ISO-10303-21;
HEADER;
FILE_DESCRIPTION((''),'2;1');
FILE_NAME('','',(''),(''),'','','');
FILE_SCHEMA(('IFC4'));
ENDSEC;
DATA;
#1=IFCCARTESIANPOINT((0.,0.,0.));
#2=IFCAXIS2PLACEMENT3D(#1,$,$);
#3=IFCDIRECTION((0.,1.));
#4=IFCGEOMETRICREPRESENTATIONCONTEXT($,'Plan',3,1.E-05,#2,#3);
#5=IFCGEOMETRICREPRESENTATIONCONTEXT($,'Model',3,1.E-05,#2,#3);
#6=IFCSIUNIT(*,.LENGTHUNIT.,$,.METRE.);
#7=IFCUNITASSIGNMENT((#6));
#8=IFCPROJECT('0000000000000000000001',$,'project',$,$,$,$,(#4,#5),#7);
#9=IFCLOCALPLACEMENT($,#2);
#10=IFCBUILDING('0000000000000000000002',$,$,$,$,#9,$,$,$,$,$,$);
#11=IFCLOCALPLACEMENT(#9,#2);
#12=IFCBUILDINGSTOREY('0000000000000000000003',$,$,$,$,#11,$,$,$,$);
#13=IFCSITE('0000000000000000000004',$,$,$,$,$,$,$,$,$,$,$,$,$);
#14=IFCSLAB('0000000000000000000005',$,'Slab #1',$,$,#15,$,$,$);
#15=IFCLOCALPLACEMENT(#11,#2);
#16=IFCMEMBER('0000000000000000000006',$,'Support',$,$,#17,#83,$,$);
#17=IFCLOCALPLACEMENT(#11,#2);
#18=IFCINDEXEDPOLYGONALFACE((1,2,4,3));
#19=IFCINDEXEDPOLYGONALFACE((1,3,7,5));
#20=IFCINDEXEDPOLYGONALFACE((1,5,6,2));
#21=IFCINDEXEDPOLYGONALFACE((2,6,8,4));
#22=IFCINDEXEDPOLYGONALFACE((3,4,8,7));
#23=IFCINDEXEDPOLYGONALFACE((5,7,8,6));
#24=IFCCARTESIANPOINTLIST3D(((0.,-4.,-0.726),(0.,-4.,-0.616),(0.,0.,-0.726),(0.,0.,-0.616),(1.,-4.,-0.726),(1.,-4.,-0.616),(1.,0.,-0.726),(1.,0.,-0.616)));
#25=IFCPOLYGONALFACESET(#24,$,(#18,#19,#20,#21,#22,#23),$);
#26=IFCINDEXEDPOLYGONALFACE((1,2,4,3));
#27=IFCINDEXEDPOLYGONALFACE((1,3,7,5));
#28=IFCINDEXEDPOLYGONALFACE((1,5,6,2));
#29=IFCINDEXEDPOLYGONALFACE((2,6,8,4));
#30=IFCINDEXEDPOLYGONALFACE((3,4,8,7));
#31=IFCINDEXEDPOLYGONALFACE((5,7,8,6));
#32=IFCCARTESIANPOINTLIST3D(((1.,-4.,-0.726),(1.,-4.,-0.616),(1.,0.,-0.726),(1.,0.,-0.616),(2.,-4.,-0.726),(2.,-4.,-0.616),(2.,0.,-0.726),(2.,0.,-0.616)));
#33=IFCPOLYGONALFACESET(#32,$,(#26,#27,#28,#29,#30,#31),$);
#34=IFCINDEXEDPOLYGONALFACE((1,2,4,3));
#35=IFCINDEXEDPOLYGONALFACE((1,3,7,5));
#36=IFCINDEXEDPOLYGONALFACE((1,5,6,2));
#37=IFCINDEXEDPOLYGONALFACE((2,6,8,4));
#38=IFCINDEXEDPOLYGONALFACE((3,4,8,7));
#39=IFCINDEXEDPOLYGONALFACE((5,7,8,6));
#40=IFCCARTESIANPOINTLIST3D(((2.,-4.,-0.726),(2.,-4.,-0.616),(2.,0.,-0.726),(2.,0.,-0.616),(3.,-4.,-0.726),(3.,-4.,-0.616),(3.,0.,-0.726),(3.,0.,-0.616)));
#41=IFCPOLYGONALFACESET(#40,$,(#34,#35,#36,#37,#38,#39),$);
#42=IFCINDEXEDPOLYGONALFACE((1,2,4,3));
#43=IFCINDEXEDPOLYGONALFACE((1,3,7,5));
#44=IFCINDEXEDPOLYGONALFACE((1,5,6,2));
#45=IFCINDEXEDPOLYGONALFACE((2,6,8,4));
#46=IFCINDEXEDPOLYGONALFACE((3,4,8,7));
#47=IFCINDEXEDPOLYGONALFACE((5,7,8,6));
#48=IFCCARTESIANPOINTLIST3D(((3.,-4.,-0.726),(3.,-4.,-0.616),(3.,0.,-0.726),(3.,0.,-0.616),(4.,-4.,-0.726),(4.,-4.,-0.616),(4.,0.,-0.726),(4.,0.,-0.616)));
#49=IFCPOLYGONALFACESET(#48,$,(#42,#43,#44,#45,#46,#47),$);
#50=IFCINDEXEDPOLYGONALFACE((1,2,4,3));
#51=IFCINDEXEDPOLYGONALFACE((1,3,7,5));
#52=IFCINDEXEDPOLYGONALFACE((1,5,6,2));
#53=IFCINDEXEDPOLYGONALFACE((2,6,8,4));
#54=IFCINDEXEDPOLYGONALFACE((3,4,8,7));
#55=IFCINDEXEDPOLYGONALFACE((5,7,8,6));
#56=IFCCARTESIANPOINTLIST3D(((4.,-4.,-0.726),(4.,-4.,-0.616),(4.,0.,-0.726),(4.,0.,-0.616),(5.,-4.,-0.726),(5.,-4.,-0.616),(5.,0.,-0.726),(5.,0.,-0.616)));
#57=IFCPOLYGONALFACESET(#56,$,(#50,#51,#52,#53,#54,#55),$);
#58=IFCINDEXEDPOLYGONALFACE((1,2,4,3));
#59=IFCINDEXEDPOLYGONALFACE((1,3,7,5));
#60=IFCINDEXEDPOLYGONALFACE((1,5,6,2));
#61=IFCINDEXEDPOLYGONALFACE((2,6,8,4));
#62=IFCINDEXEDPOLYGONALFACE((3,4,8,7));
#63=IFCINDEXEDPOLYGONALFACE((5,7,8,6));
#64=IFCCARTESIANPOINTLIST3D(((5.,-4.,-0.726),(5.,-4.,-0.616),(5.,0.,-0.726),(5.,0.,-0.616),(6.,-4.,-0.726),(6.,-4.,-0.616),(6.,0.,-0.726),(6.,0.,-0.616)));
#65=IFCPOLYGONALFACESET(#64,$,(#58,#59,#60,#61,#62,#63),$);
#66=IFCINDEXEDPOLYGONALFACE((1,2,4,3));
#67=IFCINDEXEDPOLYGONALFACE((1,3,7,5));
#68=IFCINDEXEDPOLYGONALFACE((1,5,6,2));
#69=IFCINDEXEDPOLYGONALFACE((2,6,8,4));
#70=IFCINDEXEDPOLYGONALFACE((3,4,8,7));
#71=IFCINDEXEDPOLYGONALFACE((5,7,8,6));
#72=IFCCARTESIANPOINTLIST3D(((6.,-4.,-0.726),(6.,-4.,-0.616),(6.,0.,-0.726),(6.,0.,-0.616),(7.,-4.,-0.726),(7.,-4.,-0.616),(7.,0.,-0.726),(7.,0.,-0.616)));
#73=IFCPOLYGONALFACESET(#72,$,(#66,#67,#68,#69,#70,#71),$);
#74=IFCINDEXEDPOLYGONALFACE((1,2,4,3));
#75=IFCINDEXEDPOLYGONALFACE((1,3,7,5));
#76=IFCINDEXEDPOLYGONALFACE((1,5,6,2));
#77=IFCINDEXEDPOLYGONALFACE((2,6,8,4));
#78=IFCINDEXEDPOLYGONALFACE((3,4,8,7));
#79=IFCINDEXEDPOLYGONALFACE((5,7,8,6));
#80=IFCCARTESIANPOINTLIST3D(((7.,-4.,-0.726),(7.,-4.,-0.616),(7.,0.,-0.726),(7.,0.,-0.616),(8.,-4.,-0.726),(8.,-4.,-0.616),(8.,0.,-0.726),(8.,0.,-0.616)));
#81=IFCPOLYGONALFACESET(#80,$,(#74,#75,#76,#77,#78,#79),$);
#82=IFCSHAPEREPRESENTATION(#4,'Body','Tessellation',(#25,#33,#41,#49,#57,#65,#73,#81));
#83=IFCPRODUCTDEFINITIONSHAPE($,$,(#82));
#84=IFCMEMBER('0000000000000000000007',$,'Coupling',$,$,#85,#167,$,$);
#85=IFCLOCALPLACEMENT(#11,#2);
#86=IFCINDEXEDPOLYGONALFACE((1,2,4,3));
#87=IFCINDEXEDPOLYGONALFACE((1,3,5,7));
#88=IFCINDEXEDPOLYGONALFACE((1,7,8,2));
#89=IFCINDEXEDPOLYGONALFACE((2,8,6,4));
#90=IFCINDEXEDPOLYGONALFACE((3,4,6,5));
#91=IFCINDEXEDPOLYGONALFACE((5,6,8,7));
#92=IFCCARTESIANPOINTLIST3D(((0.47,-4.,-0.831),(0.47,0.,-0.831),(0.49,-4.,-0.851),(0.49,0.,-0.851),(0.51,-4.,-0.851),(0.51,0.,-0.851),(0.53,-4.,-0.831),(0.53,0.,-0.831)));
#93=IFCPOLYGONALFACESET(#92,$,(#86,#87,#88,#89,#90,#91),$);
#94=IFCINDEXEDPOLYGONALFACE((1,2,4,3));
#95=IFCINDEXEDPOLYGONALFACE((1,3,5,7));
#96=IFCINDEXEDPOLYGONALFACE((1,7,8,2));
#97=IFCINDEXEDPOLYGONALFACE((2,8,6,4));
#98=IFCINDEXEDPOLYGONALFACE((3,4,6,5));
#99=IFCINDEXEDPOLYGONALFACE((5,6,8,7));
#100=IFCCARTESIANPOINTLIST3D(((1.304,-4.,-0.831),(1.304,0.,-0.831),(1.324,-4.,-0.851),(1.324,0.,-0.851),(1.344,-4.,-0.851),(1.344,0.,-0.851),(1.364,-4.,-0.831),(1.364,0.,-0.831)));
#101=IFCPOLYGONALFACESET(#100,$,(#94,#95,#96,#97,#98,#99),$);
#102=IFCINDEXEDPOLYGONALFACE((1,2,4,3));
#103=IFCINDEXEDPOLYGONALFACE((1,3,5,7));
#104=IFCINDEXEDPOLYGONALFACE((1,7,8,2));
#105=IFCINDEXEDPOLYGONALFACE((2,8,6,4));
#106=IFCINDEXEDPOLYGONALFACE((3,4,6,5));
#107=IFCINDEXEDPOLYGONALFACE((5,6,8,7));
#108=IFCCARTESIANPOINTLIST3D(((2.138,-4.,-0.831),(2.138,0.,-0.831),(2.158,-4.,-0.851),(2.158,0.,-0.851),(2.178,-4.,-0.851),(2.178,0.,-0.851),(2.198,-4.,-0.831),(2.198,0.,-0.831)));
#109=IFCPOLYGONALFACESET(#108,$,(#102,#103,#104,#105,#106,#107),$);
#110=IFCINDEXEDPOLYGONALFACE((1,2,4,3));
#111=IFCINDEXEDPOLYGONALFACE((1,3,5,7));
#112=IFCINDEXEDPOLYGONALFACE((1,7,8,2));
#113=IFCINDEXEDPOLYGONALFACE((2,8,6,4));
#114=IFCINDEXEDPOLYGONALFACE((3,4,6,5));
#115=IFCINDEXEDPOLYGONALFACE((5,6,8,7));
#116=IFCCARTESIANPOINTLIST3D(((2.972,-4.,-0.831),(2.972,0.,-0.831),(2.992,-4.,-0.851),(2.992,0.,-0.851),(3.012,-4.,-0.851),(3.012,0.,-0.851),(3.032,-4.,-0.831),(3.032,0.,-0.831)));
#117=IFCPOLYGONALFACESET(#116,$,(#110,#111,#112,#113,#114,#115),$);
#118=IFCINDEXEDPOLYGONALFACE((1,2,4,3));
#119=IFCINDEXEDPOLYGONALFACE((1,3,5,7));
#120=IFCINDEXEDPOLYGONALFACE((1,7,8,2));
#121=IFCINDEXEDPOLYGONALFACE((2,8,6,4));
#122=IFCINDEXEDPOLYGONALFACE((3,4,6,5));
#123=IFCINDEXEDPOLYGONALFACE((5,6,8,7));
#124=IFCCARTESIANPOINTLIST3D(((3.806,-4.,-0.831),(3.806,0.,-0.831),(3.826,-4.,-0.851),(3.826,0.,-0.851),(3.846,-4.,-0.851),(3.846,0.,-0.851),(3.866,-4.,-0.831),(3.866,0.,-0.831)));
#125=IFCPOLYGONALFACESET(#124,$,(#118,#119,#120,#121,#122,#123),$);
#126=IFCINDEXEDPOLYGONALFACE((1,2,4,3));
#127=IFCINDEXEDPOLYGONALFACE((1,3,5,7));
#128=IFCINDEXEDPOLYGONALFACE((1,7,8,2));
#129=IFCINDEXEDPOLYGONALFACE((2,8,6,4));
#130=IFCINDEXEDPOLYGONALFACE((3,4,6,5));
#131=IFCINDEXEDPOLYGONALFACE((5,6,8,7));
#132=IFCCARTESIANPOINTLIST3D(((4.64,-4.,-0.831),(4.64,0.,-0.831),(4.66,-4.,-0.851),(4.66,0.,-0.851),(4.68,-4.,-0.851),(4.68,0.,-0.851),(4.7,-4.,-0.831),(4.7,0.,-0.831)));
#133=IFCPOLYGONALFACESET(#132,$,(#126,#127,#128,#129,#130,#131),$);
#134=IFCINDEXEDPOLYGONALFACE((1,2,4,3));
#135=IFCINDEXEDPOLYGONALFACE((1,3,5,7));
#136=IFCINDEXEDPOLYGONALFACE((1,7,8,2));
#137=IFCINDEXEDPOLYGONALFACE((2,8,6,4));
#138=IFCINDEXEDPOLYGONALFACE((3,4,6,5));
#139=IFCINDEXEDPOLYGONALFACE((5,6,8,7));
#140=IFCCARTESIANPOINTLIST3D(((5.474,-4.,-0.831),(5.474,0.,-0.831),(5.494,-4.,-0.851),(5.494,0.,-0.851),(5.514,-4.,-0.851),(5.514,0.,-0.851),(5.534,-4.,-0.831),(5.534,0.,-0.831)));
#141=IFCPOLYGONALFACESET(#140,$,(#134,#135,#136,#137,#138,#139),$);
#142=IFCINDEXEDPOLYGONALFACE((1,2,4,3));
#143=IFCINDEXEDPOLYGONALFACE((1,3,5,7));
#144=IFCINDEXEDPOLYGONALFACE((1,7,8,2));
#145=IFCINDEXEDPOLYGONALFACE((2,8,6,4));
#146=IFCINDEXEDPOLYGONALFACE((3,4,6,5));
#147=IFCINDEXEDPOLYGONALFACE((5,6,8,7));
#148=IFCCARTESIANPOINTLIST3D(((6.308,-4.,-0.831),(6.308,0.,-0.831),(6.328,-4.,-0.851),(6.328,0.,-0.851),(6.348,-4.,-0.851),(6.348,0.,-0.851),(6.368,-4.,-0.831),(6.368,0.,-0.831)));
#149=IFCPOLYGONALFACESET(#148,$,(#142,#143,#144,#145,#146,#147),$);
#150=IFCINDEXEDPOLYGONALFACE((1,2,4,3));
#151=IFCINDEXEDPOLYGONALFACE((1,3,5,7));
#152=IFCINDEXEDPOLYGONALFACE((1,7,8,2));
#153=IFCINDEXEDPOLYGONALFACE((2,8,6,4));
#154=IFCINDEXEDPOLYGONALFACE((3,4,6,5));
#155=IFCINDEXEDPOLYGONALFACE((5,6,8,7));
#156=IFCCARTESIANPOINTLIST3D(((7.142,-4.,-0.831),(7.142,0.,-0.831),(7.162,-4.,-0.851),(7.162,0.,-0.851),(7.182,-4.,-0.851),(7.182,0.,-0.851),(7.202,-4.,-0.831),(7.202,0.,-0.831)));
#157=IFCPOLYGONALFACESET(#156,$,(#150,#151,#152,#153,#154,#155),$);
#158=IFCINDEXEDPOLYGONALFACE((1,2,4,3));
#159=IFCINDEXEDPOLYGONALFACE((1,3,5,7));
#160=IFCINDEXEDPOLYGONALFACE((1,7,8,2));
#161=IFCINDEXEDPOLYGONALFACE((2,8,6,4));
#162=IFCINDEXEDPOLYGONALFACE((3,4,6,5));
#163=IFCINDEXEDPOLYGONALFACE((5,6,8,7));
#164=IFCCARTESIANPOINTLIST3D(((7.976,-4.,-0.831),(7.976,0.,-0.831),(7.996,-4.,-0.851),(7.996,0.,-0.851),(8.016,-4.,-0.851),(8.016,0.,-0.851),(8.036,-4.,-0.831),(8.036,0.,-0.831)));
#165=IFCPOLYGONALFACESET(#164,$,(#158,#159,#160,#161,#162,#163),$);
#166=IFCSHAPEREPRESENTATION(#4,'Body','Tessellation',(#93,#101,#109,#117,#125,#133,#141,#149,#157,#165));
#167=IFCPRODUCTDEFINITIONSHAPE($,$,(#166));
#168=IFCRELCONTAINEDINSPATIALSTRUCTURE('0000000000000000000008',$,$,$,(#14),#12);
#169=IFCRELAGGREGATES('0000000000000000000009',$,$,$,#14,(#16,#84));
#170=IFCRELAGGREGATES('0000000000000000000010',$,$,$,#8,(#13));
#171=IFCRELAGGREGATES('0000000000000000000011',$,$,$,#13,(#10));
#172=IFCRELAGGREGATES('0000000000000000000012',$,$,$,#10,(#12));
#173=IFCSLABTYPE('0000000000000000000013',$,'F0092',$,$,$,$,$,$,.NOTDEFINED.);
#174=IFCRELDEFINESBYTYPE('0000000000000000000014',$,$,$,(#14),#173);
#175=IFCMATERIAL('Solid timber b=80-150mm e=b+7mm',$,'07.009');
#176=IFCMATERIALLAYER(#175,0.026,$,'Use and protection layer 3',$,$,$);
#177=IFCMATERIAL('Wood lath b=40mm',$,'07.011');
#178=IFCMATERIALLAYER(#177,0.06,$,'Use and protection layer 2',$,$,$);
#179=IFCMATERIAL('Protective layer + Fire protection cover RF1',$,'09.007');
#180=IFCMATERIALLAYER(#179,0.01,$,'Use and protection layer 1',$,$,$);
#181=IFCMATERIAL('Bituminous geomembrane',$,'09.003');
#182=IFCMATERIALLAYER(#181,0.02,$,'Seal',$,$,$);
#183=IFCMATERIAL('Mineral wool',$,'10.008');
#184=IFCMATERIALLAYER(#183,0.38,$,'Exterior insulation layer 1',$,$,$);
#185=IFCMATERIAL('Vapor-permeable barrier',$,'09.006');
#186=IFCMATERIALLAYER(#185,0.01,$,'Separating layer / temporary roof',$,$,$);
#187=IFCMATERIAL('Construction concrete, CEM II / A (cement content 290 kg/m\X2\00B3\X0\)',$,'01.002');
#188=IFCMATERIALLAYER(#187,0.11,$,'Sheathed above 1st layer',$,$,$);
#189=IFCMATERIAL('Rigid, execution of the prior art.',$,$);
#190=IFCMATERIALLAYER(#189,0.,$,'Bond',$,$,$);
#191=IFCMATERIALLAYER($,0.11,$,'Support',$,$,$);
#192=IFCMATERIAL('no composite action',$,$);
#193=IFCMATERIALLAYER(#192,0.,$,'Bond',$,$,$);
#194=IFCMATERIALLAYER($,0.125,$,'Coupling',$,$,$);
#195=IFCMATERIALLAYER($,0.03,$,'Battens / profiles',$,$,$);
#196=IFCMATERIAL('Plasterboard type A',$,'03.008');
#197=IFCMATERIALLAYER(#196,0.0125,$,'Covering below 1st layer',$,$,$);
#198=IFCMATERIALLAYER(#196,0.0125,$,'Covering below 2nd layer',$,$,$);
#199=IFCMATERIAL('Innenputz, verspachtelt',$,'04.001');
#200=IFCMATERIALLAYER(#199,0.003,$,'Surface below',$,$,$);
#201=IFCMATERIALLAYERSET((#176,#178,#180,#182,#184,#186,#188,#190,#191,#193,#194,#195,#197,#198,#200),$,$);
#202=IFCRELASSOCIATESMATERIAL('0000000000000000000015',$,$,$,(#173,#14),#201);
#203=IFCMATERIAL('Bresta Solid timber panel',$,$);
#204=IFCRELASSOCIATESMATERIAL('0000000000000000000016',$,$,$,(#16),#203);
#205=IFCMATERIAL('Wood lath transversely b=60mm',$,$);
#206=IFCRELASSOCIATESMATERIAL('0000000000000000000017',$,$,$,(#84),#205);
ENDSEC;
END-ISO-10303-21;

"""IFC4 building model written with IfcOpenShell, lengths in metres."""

from ifc_helpers import new_model, si_unit, direction, frame, frame_2d, origin, place, context, project, spatial, polyline, rectangle, outline, extrude, material, layer, layer_set, type_object, element, aggregate, save


model = new_model("IFC4")

# Units and contexts
plan_context = context("Plan", 3, precision=1e-05, world=origin(), true_north=direction((0.0, 1.0)))
model_context = context("Model", 3, precision=1e-05, world=origin(), true_north=direction((0.0, 1.0)))
ifc_project = project(units=[si_unit("LENGTHUNIT", "METRE")], contexts=[plan_context, model_context])

# Site, building, storey
site = spatial("IfcSite", under=ifc_project)
building_placement = place(None, origin())
building = spatial("IfcBuilding", under=site, at=building_placement)
storey_placement = place(building_placement, origin())
storey = spatial("IfcBuildingStorey", under=building, at=storey_placement)

# Slab, members
ifc_material_1 = material(Name="Solid timber b=80-150mm e=b+7mm", Category="07.009")
ifc_layer_1 = layer(ifc_material_1, 0.026, Name="Use and protection layer 3")
ifc_material_2 = material(Name="Wood lath b=40mm", Category="07.011")
ifc_layer_2 = layer(ifc_material_2, 0.06, Name="Use and protection layer 2")
ifc_material_3 = material(Name="Protective layer + Fire protection cover RF1", Category="09.007")
ifc_layer_3 = layer(ifc_material_3, 0.01, Name="Use and protection layer 1")
ifc_material_4 = material(Name="Bituminous geomembrane", Category="09.003")
ifc_layer_4 = layer(ifc_material_4, 0.02, Name="Seal")
ifc_material_5 = material(Name="Mineral wool", Category="10.008")
ifc_layer_5 = layer(ifc_material_5, 0.38, Name="Exterior insulation layer 1")
ifc_material_6 = material(Name="Vapor-permeable barrier", Category="09.006")
ifc_layer_6 = layer(ifc_material_6, 0.01, Name="Separating layer / temporary roof")
ifc_material_7 = material(Name="Construction concrete, CEM II / A (cement content 290 kg/m³)", Category="01.002")
ifc_layer_7 = layer(ifc_material_7, 0.11, Name="Sheathed above 1st layer")
ifc_material_8 = material(Name="Rigid, execution of the prior art.")
ifc_layer_8 = layer(ifc_material_8, 0.0, Name="Bond")
ifc_layer_9 = layer(None, 0.11, Name="Support")
ifc_material_9 = material(Name="no composite action")
ifc_layer_10 = layer(ifc_material_9, 0.0, Name="Bond")
ifc_layer_11 = layer(None, 0.125, Name="Coupling")
ifc_layer_12 = layer(None, 0.03, Name="Battens / profiles")
ifc_material_10 = material(Name="Plasterboard type A", Category="03.008")
ifc_layer_13 = layer(ifc_material_10, 0.0125, Name="Covering below 1st layer")
ifc_layer_14 = layer(ifc_material_10, 0.0125, Name="Covering below 2nd layer")
ifc_material_11 = material(Name="Innenputz, verspachtelt", Category="04.001")
ifc_layer_15 = layer(ifc_material_11, 0.003, Name="Surface below")
ifc_layer_set = layer_set([ifc_layer_1, ifc_layer_2, ifc_layer_3, ifc_layer_4, ifc_layer_5, ifc_layer_6, ifc_layer_7, ifc_layer_8, ifc_layer_9, ifc_layer_10, ifc_layer_11, ifc_layer_12, ifc_layer_13, ifc_layer_14, ifc_layer_15])
slab_type = type_object("IfcSlabType", Name="F0092", PredefinedType="NOTDEFINED", material=ifc_layer_set)
slab_placement = place(None, frame((0.0, 0.0, 0.0), z_axis=(0.0, 0.0, -1.0), x_axis=(1.0, 0.0, 0.0)))
slab = element("IfcSlab", 1, at=slab_placement, inside=storey, type_object=slab_type, material=ifc_layer_set, Name="Slab #1")
ifc_material_12 = material(Name="Bresta Solid timber panel")
member_1_placement = place(slab_placement, origin())
member_1 = element("IfcMember", 2, at=member_1_placement, material=ifc_material_12, Name="Support", context=plan_context, shape_type="SweptSolid", body=[
    extrude(rectangle(XDim=1.0, YDim=0.11, at=frame_2d((0.5, 0.055), x_axis=(1.0, 0.0))), frame((0.0, 4.0, 0.616), z_axis=(0.0, -1.0, 0.0), x_axis=(1.0, 0.0, 0.0)), (0.0, 0.0, 1.0), 4.0),
    extrude(rectangle(XDim=1.0, YDim=0.11, at=frame_2d((0.5, 0.055), x_axis=(1.0, 0.0))), frame((1.0, 4.0, 0.616), z_axis=(0.0, -1.0, 0.0), x_axis=(1.0, 0.0, 0.0)), (0.0, 0.0, 1.0), 4.0),
    extrude(rectangle(XDim=1.0, YDim=0.11, at=frame_2d((0.5, 0.055), x_axis=(1.0, 0.0))), frame((2.0, 4.0, 0.616), z_axis=(0.0, -1.0, 0.0), x_axis=(1.0, 0.0, 0.0)), (0.0, 0.0, 1.0), 4.0),
    extrude(rectangle(XDim=1.0, YDim=0.11, at=frame_2d((0.5, 0.055), x_axis=(1.0, 0.0))), frame((3.0, 4.0, 0.616), z_axis=(0.0, -1.0, 0.0), x_axis=(1.0, 0.0, 0.0)), (0.0, 0.0, 1.0), 4.0),
    extrude(rectangle(XDim=1.0, YDim=0.11, at=frame_2d((0.5, 0.055), x_axis=(1.0, 0.0))), frame((4.0, 4.0, 0.616), z_axis=(0.0, -1.0, 0.0), x_axis=(1.0, 0.0, 0.0)), (0.0, 0.0, 1.0), 4.0),
    extrude(rectangle(XDim=1.0, YDim=0.11, at=frame_2d((0.5, 0.055), x_axis=(1.0, 0.0))), frame((5.0, 4.0, 0.616), z_axis=(0.0, -1.0, 0.0), x_axis=(1.0, 0.0, 0.0)), (0.0, 0.0, 1.0), 4.0),
    extrude(rectangle(XDim=1.0, YDim=0.11, at=frame_2d((0.5, 0.055), x_axis=(1.0, 0.0))), frame((6.0, 4.0, 0.616), z_axis=(0.0, -1.0, 0.0), x_axis=(1.0, 0.0, 0.0)), (0.0, 0.0, 1.0), 4.0),
    extrude(rectangle(XDim=1.0, YDim=0.11, at=frame_2d((0.5, 0.055), x_axis=(1.0, 0.0))), frame((7.0, 4.0, 0.616), z_axis=(0.0, -1.0, 0.0), x_axis=(1.0, 0.0, 0.0)), (0.0, 0.0, 1.0), 4.0),
])
ifc_material_13 = material(Name="Wood lath transversely b=60mm")
member_2_placement = place(slab_placement, origin())
member_2 = element("IfcMember", 3, at=member_2_placement, material=ifc_material_13, Name="Coupling", context=plan_context, shape_type="SweptSolid", body=[
    extrude(outline(polyline([(0.0, 0.0), (0.06, 0.0), (0.04, 0.02), (0.02, 0.02), (0.0, 0.0)])), frame((0.47, 4.0, 0.831), z_axis=(0.0, -1.0, 0.0), x_axis=(1.0, 0.0, 0.0)), (0.0, 0.0, 1.0), 4.0),
    extrude(outline(polyline([(0.0, 0.0), (0.06, 0.0), (0.04, 0.02), (0.02, 0.02), (0.0, 0.0)])), frame((1.304, 4.0, 0.831), z_axis=(0.0, -1.0, 0.0), x_axis=(1.0, 0.0, 0.0)), (0.0, 0.0, 1.0), 4.0),
    extrude(outline(polyline([(0.0, 0.0), (0.06, 0.0), (0.04, 0.02), (0.02, 0.02), (0.0, 0.0)])), frame((2.138, 4.0, 0.831), z_axis=(0.0, -1.0, 0.0), x_axis=(1.0, 0.0, 0.0)), (0.0, 0.0, 1.0), 4.0),
    extrude(outline(polyline([(0.0, 0.0), (0.06, 0.0), (0.04, 0.02), (0.02, 0.02), (0.0, 0.0)])), frame((2.972, 4.0, 0.831), z_axis=(0.0, -1.0, 0.0), x_axis=(1.0, 0.0, 0.0)), (0.0, 0.0, 1.0), 4.0),
    extrude(outline(polyline([(0.0, 0.0), (0.06, 0.0), (0.04, 0.02), (0.02, 0.02), (0.0, 0.0)])), frame((3.806, 4.0, 0.831), z_axis=(0.0, -1.0, 0.0), x_axis=(1.0, 0.0, 0.0)), (0.0, 0.0, 1.0), 4.0),
    extrude(outline(polyline([(0.0, 0.0), (0.06, 0.0), (0.04, 0.02), (0.02, 0.02), (0.0, 0.0)])), frame((4.64, 4.0, 0.831), z_axis=(0.0, -1.0, 0.0), x_axis=(1.0, 0.0, 0.0)), (0.0, 0.0, 1.0), 4.0),
    extrude(outline(polyline([(0.0, 0.0), (0.06, 0.0), (0.04, 0.02), (0.02, 0.02), (0.0, 0.0)])), frame((5.474, 4.0, 0.831), z_axis=(0.0, -1.0, 0.0), x_axis=(1.0, 0.0, 0.0)), (0.0, 0.0, 1.0), 4.0),
    extrude(outline(polyline([(0.0, 0.0), (0.06, 0.0), (0.04, 0.02), (0.02, 0.02), (0.0, 0.0)])), frame((6.308, 4.0, 0.831), z_axis=(0.0, -1.0, 0.0), x_axis=(1.0, 0.0, 0.0)), (0.0, 0.0, 1.0), 4.0),
    extrude(outline(polyline([(0.0, 0.0), (0.06, 0.0), (0.04, 0.02), (0.02, 0.02), (0.0, 0.0)])), frame((7.142, 4.0, 0.831), z_axis=(0.0, -1.0, 0.0), x_axis=(1.0, 0.0, 0.0)), (0.0, 0.0, 1.0), 4.0),
    extrude(outline(polyline([(0.0, 0.0), (0.06, 0.0), (0.04, 0.02), (0.02, 0.02), (0.0, 0.0)])), frame((7.976, 4.0, 0.831), z_axis=(0.0, -1.0, 0.0), x_axis=(1.0, 0.0, 0.0)), (0.0, 0.0, 1.0), 4.0),
])
aggregate(slab, [member_1, member_2])

save(model, "model.ifc")
